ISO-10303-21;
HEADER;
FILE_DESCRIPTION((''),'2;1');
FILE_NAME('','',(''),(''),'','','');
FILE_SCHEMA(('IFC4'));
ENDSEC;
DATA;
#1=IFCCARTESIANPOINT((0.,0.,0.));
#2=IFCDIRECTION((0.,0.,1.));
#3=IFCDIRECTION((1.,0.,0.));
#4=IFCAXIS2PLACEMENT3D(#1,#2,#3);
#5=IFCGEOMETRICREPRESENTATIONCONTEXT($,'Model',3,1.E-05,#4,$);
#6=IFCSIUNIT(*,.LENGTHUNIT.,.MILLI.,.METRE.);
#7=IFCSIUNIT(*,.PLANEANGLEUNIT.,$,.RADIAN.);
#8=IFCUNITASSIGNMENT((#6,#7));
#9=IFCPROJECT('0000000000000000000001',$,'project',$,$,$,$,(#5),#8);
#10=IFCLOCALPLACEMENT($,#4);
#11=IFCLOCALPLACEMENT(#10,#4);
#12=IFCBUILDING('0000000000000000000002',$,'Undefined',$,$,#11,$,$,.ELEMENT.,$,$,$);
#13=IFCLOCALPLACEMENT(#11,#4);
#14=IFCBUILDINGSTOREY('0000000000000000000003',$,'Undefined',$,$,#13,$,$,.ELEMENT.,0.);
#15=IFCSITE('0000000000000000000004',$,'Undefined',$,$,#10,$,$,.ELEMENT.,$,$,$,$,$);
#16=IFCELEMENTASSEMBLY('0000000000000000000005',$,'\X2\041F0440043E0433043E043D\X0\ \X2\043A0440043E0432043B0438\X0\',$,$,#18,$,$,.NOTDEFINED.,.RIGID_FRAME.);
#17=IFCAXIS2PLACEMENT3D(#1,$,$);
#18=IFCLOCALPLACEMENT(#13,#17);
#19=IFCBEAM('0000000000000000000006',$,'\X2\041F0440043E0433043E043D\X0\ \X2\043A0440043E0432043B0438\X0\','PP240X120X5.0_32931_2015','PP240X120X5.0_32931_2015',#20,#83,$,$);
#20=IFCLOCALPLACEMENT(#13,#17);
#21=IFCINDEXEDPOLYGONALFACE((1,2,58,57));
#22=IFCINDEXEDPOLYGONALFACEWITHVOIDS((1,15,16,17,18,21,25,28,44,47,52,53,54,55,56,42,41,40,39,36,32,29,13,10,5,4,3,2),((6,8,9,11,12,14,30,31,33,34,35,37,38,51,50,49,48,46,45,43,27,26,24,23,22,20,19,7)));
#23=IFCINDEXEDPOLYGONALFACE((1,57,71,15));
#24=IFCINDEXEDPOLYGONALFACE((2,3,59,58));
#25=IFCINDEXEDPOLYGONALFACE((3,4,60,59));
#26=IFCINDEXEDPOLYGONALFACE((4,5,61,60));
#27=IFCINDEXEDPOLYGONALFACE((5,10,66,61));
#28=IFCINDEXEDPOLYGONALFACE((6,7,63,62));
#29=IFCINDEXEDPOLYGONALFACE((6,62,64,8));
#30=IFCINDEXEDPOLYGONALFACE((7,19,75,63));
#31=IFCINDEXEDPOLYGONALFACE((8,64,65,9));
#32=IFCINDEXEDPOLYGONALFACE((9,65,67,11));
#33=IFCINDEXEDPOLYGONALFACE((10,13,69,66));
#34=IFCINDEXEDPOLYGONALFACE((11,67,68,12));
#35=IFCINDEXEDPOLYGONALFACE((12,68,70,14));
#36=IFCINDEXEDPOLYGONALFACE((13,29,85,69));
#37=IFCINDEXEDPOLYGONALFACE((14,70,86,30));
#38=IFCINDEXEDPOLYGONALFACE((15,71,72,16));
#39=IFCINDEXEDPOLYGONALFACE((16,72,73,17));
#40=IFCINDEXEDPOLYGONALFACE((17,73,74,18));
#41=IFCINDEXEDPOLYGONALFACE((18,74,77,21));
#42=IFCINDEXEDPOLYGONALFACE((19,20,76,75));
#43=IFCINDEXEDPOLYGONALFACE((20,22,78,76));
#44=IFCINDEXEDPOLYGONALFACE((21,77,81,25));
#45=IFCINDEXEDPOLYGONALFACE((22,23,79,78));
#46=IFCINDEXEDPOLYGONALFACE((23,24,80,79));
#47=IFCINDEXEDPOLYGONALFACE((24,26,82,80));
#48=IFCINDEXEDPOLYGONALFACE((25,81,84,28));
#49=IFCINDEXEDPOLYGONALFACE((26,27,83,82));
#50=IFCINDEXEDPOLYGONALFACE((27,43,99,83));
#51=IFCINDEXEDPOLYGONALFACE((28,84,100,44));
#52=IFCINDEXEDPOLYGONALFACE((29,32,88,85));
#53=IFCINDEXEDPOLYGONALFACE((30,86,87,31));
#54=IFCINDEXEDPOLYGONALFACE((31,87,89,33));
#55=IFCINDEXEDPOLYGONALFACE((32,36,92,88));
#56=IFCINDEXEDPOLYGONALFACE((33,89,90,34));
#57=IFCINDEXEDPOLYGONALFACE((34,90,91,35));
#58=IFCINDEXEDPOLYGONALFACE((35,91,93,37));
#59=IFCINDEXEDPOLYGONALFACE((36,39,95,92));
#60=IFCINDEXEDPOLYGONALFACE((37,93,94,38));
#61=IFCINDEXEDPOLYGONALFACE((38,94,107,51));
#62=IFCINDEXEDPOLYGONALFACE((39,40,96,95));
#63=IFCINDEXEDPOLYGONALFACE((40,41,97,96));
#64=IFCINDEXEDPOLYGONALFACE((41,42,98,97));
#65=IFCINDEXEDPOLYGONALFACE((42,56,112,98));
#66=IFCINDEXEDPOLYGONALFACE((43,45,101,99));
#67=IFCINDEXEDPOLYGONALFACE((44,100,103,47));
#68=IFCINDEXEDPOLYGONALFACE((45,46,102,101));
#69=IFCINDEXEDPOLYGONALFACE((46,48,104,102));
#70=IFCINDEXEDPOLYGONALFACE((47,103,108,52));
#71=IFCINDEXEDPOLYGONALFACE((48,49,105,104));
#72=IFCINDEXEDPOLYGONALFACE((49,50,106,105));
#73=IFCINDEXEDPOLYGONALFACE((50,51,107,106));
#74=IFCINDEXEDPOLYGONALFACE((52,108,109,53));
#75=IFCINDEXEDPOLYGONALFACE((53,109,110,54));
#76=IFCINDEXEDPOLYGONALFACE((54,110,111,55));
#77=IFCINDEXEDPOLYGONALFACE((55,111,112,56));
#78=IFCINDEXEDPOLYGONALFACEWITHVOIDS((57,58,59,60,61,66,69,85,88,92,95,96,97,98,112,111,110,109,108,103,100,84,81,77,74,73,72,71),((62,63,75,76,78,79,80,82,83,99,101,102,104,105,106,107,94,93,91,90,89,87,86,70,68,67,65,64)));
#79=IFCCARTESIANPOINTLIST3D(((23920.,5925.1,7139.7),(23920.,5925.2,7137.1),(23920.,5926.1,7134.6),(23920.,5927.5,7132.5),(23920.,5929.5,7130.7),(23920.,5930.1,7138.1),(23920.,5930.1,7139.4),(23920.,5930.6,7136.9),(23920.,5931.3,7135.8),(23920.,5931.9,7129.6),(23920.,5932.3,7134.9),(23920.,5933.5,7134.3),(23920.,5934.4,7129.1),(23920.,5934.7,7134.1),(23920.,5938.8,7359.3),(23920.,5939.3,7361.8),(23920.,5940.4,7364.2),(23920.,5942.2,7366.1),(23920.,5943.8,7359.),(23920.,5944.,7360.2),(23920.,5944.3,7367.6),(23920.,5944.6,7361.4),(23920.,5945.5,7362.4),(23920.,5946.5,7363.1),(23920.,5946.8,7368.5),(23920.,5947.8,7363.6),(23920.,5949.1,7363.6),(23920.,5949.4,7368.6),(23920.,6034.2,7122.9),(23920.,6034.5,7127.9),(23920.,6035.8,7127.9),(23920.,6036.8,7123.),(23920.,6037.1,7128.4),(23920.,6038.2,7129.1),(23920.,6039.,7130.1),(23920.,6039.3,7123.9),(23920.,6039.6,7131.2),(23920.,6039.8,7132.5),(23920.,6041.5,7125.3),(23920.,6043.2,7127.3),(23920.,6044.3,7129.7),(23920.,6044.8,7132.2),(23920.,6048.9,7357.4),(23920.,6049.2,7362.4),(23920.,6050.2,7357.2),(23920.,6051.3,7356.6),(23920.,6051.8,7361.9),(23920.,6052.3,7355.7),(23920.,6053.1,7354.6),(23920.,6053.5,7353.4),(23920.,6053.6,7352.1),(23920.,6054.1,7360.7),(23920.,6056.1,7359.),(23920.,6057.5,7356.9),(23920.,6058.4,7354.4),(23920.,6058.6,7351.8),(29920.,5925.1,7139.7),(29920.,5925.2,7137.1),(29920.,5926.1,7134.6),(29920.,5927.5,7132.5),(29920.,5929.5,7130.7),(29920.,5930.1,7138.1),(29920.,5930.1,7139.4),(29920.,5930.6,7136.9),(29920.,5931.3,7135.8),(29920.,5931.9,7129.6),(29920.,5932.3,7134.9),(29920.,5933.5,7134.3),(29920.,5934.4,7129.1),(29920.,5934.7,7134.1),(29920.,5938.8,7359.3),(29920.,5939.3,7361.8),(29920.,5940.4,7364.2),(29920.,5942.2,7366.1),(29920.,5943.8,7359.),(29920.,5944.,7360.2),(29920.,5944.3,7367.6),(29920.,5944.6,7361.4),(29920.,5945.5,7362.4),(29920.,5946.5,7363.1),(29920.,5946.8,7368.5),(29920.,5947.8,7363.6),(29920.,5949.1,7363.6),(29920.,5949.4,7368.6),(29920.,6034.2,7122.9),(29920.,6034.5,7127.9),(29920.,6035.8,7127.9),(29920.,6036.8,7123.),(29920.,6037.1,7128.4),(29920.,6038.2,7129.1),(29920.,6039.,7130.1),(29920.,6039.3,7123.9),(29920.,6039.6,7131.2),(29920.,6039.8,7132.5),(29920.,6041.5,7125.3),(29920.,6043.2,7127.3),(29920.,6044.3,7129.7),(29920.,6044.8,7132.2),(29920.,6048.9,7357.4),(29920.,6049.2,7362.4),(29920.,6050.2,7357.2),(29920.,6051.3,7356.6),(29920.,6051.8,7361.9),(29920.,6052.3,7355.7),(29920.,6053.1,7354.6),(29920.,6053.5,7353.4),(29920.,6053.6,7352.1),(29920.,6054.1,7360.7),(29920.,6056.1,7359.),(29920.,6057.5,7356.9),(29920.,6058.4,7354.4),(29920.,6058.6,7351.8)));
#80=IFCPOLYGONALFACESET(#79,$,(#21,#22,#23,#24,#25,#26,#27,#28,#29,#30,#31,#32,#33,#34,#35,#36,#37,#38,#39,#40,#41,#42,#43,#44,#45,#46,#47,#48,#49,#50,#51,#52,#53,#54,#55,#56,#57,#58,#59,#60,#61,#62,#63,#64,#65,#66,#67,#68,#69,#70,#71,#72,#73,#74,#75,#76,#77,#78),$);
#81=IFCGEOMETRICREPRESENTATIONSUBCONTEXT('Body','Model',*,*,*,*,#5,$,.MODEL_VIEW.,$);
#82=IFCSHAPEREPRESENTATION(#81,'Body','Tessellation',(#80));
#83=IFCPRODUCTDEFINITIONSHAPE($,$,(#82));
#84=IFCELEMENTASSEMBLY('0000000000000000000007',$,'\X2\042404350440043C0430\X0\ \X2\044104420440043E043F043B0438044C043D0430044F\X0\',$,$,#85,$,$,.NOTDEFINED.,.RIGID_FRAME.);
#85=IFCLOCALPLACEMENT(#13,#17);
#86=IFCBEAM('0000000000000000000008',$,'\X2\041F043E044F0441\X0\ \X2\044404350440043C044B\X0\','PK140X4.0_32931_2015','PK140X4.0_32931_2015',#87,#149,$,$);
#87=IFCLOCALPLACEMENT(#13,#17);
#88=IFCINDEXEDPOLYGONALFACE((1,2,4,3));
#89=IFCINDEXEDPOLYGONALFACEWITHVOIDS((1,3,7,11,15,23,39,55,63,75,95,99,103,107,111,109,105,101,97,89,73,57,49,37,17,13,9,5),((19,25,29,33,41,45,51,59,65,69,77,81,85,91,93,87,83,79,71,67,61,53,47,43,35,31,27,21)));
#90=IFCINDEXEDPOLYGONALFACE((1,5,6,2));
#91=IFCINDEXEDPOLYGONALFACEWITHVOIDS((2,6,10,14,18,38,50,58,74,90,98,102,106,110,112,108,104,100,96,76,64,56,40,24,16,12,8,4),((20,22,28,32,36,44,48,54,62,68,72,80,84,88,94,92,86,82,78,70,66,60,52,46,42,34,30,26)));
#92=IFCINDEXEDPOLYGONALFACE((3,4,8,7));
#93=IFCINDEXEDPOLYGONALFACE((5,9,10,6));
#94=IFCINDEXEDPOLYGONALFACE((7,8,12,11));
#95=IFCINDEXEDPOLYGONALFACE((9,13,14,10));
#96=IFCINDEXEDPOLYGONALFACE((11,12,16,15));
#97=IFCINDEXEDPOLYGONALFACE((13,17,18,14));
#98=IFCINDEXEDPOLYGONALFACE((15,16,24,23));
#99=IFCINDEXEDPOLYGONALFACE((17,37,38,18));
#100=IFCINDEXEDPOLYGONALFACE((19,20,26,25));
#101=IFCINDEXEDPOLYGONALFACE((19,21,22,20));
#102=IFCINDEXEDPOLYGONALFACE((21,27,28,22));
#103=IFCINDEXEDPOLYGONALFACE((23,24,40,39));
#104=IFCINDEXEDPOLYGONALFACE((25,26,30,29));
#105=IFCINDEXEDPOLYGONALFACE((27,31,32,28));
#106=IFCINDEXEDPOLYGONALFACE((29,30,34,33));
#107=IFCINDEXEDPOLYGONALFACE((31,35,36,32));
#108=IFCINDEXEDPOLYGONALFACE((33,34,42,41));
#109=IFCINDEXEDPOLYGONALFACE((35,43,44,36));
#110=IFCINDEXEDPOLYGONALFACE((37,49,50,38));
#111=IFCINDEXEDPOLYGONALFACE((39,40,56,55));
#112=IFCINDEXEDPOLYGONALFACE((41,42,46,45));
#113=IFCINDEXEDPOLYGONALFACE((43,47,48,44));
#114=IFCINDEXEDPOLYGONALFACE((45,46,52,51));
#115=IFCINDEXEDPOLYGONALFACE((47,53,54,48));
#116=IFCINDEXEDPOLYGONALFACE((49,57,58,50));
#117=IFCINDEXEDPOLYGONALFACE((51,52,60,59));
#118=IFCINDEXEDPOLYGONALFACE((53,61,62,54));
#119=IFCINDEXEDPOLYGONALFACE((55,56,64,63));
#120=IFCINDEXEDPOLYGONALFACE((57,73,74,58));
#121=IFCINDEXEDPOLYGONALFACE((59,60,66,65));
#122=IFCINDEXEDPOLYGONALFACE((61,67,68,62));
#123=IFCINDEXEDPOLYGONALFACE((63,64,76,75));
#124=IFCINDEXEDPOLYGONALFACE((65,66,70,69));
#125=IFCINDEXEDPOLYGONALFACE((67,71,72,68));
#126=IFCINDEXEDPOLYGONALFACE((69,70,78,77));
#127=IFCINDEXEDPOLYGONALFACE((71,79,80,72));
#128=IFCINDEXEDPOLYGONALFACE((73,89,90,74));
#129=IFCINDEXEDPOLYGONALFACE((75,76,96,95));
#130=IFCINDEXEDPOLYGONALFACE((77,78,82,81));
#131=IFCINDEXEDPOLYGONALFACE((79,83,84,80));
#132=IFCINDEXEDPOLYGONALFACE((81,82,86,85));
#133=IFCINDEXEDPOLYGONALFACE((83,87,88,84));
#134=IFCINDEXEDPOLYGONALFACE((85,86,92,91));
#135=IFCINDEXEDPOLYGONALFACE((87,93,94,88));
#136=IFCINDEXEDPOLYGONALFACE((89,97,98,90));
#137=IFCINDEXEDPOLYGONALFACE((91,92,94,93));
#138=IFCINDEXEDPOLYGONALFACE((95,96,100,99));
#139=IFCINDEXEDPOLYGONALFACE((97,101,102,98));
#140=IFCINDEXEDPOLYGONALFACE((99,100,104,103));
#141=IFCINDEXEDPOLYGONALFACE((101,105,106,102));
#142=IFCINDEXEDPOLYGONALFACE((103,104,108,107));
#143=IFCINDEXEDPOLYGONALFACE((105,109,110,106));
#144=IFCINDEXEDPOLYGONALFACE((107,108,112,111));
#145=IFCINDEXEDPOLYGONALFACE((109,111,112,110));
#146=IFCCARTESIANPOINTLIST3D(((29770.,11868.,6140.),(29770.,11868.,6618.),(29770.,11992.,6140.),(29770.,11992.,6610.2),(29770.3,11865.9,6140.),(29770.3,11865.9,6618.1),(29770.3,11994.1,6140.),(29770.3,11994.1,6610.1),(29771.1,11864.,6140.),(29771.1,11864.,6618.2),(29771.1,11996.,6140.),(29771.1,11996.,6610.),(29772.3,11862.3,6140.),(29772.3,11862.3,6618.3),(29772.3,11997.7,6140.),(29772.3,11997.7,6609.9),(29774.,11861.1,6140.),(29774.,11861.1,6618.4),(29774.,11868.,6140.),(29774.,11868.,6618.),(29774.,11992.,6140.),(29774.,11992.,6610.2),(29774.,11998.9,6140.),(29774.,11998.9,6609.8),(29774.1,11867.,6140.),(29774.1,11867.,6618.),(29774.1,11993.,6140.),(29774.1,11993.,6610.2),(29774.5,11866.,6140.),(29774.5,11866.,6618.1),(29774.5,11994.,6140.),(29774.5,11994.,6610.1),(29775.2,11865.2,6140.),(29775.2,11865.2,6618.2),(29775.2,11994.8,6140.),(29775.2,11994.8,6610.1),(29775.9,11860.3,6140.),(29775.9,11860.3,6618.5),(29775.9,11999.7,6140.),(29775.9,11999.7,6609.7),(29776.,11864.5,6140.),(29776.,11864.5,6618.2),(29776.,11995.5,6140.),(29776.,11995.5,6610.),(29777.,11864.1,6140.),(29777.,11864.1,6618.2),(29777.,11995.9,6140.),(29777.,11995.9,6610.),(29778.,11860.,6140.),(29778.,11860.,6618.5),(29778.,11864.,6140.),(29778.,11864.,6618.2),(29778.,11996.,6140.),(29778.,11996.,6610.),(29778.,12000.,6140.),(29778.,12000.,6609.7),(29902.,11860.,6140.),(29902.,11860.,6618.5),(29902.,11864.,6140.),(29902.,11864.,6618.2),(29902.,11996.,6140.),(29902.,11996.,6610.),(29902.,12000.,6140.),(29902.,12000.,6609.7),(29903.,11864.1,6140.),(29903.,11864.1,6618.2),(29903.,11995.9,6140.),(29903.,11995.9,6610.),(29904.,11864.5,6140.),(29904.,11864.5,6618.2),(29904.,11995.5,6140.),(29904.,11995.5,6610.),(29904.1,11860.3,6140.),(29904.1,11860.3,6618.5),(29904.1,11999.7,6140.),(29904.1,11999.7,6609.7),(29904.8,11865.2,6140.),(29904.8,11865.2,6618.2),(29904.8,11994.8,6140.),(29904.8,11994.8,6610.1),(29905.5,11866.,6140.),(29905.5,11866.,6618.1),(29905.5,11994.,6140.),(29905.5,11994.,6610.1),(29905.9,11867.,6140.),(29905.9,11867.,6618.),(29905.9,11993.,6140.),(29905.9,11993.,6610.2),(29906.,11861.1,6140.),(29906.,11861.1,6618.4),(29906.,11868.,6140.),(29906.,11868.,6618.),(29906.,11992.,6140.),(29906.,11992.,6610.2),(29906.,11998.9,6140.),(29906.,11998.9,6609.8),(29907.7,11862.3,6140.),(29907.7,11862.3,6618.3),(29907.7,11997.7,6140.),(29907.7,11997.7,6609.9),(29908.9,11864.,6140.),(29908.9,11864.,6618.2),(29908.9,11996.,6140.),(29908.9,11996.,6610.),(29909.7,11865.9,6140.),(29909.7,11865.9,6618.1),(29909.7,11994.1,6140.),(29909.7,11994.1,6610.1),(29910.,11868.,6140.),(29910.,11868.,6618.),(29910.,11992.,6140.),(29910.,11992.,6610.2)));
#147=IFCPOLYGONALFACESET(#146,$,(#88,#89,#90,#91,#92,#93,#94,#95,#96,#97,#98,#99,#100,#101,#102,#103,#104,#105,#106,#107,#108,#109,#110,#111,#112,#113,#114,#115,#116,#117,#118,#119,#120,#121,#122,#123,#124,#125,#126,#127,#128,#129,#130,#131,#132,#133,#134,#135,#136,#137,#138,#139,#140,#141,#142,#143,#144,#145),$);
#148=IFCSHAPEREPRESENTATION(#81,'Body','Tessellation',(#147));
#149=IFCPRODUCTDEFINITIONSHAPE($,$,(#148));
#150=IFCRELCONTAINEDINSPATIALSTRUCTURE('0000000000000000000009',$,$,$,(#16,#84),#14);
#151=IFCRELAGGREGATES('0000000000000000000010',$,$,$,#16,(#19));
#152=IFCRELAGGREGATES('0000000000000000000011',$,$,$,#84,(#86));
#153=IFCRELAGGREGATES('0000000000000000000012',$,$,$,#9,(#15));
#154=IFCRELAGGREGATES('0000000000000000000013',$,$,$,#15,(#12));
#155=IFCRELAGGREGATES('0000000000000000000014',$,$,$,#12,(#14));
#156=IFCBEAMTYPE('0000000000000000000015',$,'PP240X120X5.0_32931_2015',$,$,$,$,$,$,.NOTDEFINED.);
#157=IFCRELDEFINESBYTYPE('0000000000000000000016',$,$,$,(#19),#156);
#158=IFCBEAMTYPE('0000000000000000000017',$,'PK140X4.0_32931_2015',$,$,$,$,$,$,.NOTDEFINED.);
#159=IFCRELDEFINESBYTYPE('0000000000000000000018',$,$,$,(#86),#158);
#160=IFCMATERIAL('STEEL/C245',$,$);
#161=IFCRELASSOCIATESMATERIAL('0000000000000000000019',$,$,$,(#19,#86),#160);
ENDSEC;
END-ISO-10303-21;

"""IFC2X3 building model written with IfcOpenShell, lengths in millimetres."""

from ifc_helpers import new_model, si_unit, frame, origin_with_axes, origin_2d_with_axis, place, context, subcontext, project, spatial, hollow_rectangle, extrude, clip, halfspace, material, type_object, element, aggregate, save


model = new_model("IFC2X3")

# Units and contexts
model_context = context("Model", 3, precision=1e-05, world=origin_with_axes())
body_context = subcontext(model_context, "Body", "Model", "MODEL_VIEW")
ifc_project = project(units=[si_unit("LENGTHUNIT", "METRE", prefix="MILLI"), si_unit("PLANEANGLEUNIT", "RADIAN")], contexts=[model_context])

# Site, building, storey
site_placement = place(None, origin_with_axes())
site = spatial("IfcSite", under=ifc_project, at=site_placement, Name="Undefined", CompositionType="ELEMENT")
building_placement = place(site_placement, origin_with_axes())
building = spatial("IfcBuilding", under=site, at=building_placement, Name="Undefined", CompositionType="ELEMENT")
storey_placement = place(building_placement, origin_with_axes())
storey = spatial("IfcBuildingStorey", under=building, at=storey_placement, Name="Undefined", CompositionType="ELEMENT", Elevation=0.0)

# Shared definitions
ifc_material = material(Name="STEEL/C245")

# Element assembly, beam
beam_type_1 = type_object("IfcBeamType", Name="PP240X120X5.0_32931_2015", PredefinedType="NOTDEFINED")
assembly_1_placement = place(storey_placement, origin_with_axes())
assembly_1 = element("IfcElementAssembly", 1, at=assembly_1_placement, inside=storey, Name="Прогон кровли", AssemblyPlace="NOTDEFINED", PredefinedType="RIGID_FRAME")
beam_1_placement = place(assembly_1_placement, frame((29920.0, 5991.8, 7245.7), z_axis=(0.0, 0.062378, 0.998053), x_axis=(-1.0, 0.0, 0.0)))
beam_1 = element("IfcBeam", 2, at=beam_1_placement, type_object=beam_type_1, material=ifc_material, Name="Прогон кровли", Description="PP240X120X5.0_32931_2015", ObjectType="PP240X120X5.0_32931_2015", context=body_context, shape_type="SweptSolid", body=[
    extrude(hollow_rectangle(XDim=120.0, YDim=240.0, WallThickness=5.0, InnerFilletRadius=5.0, OuterFilletRadius=10.0, at=origin_2d_with_axis()), frame((6000.0, 0.0, 0.0), z_axis=(-1.0, 0.0, 0.0), x_axis=(0.0, -1.0, 0.0)), (0.0, 0.0, 1.0), 6000.0),
])
aggregate(assembly_1, [beam_1])

# Element assembly, beam
assembly_2_placement = place(storey_placement, origin_with_axes())
assembly_2 = element("IfcElementAssembly", 3, at=assembly_2_placement, inside=storey, Name="Ферма строплиьная", AssemblyPlace="NOTDEFINED", PredefinedType="RIGID_FRAME")
beam_type_2 = type_object("IfcBeamType", Name="PK140X4.0_32931_2015", PredefinedType="NOTDEFINED")
beam_2_placement = place(assembly_2_placement, frame((29840.0, 11930.0, 6609.7), z_axis=(1.0, 0.0, 0.0), x_axis=(0.0, 0.0, -1.0)))
beam_2 = element("IfcBeam", 4, at=beam_2_placement, type_object=beam_type_2, material=ifc_material, Name="Пояс фермы", Description="PK140X4.0_32931_2015", ObjectType="PK140X4.0_32931_2015", context=body_context, shape_type="Clipping", body=[
    clip(extrude(hollow_rectangle(XDim=140.0, YDim=140.0, WallThickness=4.0, InnerFilletRadius=4.0, OuterFilletRadius=8.0, at=origin_2d_with_axis()), frame((469.7, 0.0, 0.0), z_axis=(-1.0, 0.0, 0.0), x_axis=(0.0, -1.0, 0.0)), (0.0, 0.0, 1.0), 478.5), halfspace(frame((-14.9, -167.6, 0.0), z_axis=(-0.998053, 0.062378, 0.0), x_axis=(0.0, 0.0, 1.0)), False)),
])
aggregate(assembly_2, [beam_2])

save(model, "model.ifc")
